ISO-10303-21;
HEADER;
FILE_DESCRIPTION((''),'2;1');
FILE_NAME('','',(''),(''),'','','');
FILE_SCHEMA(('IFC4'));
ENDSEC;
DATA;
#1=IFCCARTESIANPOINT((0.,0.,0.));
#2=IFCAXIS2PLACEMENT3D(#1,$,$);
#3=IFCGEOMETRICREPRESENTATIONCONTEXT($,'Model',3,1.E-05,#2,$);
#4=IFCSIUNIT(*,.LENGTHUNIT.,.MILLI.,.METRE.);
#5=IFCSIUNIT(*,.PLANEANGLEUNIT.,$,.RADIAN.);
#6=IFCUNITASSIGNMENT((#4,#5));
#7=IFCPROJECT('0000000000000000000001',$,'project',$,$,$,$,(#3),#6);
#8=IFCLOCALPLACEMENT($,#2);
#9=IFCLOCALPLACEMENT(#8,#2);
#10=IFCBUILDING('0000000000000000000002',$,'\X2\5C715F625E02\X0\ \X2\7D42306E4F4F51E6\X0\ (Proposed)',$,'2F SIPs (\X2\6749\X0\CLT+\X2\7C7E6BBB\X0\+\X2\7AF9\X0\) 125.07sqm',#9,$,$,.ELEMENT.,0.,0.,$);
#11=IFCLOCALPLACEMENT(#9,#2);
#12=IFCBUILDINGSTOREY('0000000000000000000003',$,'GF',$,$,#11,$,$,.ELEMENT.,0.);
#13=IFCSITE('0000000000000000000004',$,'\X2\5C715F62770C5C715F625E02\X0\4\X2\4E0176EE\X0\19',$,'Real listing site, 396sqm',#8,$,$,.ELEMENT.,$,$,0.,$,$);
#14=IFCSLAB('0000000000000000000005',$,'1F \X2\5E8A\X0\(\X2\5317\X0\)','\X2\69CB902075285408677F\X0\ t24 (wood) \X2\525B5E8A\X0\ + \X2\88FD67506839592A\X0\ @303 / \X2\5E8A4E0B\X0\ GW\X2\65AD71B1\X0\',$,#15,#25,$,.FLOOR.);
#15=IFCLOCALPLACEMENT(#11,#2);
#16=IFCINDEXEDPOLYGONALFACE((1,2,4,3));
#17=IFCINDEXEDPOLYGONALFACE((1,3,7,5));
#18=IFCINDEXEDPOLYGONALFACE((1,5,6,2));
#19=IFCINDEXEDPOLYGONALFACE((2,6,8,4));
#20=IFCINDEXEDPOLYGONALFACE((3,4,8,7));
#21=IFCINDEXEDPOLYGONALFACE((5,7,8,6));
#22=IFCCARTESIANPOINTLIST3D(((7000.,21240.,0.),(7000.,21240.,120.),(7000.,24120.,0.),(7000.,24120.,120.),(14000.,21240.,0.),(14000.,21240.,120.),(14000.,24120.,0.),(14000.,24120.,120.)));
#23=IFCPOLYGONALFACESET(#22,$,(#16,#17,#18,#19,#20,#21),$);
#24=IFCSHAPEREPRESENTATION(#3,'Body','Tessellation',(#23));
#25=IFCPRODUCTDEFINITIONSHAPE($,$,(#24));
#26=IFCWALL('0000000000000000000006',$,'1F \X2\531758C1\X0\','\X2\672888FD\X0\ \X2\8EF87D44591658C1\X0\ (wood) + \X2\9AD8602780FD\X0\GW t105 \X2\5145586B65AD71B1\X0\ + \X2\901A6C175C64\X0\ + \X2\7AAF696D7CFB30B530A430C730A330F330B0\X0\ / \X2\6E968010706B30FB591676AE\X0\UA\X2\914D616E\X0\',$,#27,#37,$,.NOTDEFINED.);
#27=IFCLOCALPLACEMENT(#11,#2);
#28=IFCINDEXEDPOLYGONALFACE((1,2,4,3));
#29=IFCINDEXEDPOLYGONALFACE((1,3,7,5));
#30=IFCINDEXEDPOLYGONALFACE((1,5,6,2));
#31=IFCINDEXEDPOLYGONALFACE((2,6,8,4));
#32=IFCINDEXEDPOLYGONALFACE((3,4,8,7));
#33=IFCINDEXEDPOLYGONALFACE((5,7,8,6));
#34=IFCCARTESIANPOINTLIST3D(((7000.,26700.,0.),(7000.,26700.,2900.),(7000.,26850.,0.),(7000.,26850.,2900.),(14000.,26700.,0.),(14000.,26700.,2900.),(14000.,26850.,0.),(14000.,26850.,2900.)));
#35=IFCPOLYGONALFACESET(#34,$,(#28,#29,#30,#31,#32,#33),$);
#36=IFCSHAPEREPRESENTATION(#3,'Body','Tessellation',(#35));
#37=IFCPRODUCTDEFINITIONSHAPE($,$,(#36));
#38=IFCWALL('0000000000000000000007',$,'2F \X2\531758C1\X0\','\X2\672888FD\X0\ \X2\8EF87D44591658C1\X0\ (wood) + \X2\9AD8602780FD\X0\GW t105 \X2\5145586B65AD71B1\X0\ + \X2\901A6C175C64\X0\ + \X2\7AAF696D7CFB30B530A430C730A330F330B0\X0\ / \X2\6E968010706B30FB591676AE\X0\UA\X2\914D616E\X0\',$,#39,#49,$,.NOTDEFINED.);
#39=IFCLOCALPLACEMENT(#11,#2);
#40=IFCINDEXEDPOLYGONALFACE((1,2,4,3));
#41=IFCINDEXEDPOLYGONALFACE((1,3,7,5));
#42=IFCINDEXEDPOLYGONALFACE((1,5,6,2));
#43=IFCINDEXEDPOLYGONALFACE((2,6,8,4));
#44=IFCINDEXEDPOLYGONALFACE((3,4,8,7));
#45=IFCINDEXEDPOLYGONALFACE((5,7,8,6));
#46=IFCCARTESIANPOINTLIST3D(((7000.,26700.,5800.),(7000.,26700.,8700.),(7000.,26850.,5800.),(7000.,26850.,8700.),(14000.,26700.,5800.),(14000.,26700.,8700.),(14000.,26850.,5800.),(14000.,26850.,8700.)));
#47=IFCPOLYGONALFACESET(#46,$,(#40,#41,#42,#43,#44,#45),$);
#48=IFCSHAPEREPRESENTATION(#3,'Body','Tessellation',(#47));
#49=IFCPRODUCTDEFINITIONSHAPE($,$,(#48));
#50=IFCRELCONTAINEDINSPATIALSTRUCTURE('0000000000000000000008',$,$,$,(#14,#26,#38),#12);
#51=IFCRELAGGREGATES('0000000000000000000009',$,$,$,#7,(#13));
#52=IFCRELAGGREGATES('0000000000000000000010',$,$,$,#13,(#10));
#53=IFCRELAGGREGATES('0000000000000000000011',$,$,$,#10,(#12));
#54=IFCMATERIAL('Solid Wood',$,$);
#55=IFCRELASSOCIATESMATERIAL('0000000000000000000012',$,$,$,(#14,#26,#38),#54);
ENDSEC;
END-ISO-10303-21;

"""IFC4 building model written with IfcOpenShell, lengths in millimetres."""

from ifc_helpers import new_model, si_unit, frame, frame_2d, origin, place, context, project, spatial, rectangle, extrude, material, element, save


model = new_model("IFC4")

# Units and contexts
model_context = context("Model", 3, precision=1e-05, world=origin())
ifc_project = project(units=[si_unit("LENGTHUNIT", "METRE", prefix="MILLI"), si_unit("PLANEANGLEUNIT", "RADIAN")], contexts=[model_context])

# Site, building, storey
site_placement = place(None, origin())
site = spatial("IfcSite", under=ifc_project, at=site_placement, Name="山形県山形市4丁目19", ObjectType="Real listing site, 396sqm", CompositionType="ELEMENT", RefElevation=0.0)
building_placement = place(site_placement, origin())
building = spatial("IfcBuilding", under=site, at=building_placement, Name="山形市 終の住処 (Proposed)", ObjectType="2F SIPs (杉CLT+籾殻+竹) 125.07sqm", CompositionType="ELEMENT", ElevationOfRefHeight=0.0, ElevationOfTerrain=0.0)
storey_placement = place(building_placement, origin())
storey = spatial("IfcBuildingStorey", under=building, at=storey_placement, Name="GF", CompositionType="ELEMENT", Elevation=0.0)

# Slab
ifc_material_1 = material(Name="Solid Wood")
slab_1_placement = place(storey_placement, frame((3500.0, 10620.0, 0.0)))
element("IfcSlab", 1, at=slab_1_placement, inside=storey, material=ifc_material_1, Name="1F 床(北)", Description="構造用合板 t24 (wood) 剛床 + 製材根太 @303 / 床下 GW断熱", PredefinedType="FLOOR", context=model_context, shape_type="SweptSolid", body=[
    extrude(rectangle(XDim=7000.0, YDim=2880.0, at=frame_2d((3500.0, 1440.0))), frame((3500.0, 10620.0, 0.0)), (0.0, 0.0, 1.0), 120.0),
])

# Wall
wall_1_placement = place(storey_placement, frame((3500.0, 13350.0, 0.0)))
element("IfcWall", 2, at=wall_1_placement, inside=storey, material=ifc_material_1, Name="1F 北壁", Description="木製 軸組外壁 (wood) + 高性能GW t105 充填断熱 + 通気層 + 窯業系サイディング / 準耐火・外皮UA配慮", PredefinedType="NOTDEFINED", context=model_context, shape_type="SweptSolid", body=[
    extrude(rectangle(XDim=7000.0, YDim=150.0, at=frame_2d((3500.0, 75.0))), frame((3500.0, 13350.0, 0.0)), (0.0, 0.0, 1.0), 2900.0),
])

# Wall
wall_2_placement = place(storey_placement, frame((3500.0, 13350.0, 2900.0)))
element("IfcWall", 3, at=wall_2_placement, inside=storey, material=ifc_material_1, Name="2F 北壁", Description="木製 軸組外壁 (wood) + 高性能GW t105 充填断熱 + 通気層 + 窯業系サイディング / 準耐火・外皮UA配慮", PredefinedType="NOTDEFINED", context=model_context, shape_type="SweptSolid", body=[
    extrude(rectangle(XDim=7000.0, YDim=150.0, at=frame_2d((3500.0, 75.0))), frame((3500.0, 13350.0, 2900.0)), (0.0, 0.0, 1.0), 2900.0),
])

save(model, "model.ifc")
